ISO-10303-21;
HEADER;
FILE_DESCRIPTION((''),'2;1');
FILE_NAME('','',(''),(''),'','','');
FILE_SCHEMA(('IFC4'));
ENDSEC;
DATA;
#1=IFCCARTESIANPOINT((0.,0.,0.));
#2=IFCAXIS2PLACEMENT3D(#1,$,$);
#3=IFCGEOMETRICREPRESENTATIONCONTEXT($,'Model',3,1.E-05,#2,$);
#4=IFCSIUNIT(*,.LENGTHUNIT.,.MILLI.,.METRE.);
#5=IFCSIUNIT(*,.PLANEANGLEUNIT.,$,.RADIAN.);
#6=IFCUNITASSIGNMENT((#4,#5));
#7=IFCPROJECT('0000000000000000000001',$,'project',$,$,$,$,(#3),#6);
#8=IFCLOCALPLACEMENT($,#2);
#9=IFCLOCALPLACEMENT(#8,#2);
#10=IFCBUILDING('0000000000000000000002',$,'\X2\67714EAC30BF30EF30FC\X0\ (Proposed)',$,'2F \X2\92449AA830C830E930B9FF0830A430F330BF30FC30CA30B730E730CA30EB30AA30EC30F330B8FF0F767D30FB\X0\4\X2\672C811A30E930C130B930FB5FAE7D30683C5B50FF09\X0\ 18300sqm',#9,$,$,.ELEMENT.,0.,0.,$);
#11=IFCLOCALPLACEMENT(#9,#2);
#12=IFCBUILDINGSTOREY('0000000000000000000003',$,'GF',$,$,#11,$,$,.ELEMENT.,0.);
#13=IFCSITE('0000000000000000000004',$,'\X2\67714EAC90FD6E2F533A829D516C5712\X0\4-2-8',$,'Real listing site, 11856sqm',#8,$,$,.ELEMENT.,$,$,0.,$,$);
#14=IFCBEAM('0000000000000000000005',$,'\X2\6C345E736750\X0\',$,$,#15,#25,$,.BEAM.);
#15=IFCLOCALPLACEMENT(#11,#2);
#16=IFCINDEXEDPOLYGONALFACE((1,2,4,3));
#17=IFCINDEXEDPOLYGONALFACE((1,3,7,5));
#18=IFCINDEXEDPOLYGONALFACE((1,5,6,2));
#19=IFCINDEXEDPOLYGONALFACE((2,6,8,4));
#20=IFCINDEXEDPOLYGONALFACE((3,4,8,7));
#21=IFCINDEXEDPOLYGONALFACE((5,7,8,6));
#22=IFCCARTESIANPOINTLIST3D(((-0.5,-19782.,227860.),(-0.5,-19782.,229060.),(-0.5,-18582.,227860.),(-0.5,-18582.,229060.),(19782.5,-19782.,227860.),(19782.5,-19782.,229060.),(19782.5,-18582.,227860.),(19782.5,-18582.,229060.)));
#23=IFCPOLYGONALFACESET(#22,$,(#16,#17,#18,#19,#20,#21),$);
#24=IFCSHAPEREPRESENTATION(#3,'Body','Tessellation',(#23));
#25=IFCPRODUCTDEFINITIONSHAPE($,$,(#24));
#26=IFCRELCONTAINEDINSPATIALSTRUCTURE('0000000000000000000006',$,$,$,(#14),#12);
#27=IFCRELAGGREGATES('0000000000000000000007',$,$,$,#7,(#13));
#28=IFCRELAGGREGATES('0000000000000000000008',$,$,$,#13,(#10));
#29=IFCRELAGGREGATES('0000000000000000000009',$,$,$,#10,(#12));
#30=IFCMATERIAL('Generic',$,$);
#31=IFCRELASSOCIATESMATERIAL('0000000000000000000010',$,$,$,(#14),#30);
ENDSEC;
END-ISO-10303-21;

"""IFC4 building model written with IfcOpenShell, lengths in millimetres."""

from ifc_helpers import new_model, si_unit, frame, frame_2d, origin, place, context, project, spatial, rectangle, extrude, material, element, save


model = new_model("IFC4")

# Units and contexts
model_context = context("Model", 3, precision=1e-05, world=origin())
ifc_project = project(units=[si_unit("LENGTHUNIT", "METRE", prefix="MILLI"), si_unit("PLANEANGLEUNIT", "RADIAN")], contexts=[model_context])

# Site, building, storey
site_placement = place(None, origin())
site = spatial("IfcSite", under=ifc_project, at=site_placement, Name="東京都港区芝公園4-2-8", ObjectType="Real listing site, 11856sqm", CompositionType="ELEMENT", RefElevation=0.0)
building_placement = place(site_placement, origin())
building = spatial("IfcBuilding", under=site, at=building_placement, Name="東京タワー (Proposed)", ObjectType="2F 鉄骨トラス（インターナショナルオレンジ／白・4本脚ラチス・微細格子） 18300sqm", CompositionType="ELEMENT", ElevationOfRefHeight=0.0, ElevationOfTerrain=0.0)
storey_placement = place(building_placement, origin())
storey = spatial("IfcBuildingStorey", under=building, at=storey_placement, Name="GF", CompositionType="ELEMENT", Elevation=0.0)

# Shared definitions
ifc_material = material(Name="Generic")

# Beam
beam_placement = place(storey_placement, frame((0.0, -9891.0, 113930.0)))
element("IfcBeam", 1, at=beam_placement, inside=storey, material=ifc_material, Name="水平材", PredefinedType="BEAM", context=model_context, shape_type="SweptSolid", body=[
    extrude(rectangle(XDim=19783.0, YDim=1200.0, at=frame_2d((9891.0, 600.0))), frame((0.0, -9891.0, 113930.0)), (0.0, 0.0, 1.0), 1200.0),
])

save(model, "model.ifc")
